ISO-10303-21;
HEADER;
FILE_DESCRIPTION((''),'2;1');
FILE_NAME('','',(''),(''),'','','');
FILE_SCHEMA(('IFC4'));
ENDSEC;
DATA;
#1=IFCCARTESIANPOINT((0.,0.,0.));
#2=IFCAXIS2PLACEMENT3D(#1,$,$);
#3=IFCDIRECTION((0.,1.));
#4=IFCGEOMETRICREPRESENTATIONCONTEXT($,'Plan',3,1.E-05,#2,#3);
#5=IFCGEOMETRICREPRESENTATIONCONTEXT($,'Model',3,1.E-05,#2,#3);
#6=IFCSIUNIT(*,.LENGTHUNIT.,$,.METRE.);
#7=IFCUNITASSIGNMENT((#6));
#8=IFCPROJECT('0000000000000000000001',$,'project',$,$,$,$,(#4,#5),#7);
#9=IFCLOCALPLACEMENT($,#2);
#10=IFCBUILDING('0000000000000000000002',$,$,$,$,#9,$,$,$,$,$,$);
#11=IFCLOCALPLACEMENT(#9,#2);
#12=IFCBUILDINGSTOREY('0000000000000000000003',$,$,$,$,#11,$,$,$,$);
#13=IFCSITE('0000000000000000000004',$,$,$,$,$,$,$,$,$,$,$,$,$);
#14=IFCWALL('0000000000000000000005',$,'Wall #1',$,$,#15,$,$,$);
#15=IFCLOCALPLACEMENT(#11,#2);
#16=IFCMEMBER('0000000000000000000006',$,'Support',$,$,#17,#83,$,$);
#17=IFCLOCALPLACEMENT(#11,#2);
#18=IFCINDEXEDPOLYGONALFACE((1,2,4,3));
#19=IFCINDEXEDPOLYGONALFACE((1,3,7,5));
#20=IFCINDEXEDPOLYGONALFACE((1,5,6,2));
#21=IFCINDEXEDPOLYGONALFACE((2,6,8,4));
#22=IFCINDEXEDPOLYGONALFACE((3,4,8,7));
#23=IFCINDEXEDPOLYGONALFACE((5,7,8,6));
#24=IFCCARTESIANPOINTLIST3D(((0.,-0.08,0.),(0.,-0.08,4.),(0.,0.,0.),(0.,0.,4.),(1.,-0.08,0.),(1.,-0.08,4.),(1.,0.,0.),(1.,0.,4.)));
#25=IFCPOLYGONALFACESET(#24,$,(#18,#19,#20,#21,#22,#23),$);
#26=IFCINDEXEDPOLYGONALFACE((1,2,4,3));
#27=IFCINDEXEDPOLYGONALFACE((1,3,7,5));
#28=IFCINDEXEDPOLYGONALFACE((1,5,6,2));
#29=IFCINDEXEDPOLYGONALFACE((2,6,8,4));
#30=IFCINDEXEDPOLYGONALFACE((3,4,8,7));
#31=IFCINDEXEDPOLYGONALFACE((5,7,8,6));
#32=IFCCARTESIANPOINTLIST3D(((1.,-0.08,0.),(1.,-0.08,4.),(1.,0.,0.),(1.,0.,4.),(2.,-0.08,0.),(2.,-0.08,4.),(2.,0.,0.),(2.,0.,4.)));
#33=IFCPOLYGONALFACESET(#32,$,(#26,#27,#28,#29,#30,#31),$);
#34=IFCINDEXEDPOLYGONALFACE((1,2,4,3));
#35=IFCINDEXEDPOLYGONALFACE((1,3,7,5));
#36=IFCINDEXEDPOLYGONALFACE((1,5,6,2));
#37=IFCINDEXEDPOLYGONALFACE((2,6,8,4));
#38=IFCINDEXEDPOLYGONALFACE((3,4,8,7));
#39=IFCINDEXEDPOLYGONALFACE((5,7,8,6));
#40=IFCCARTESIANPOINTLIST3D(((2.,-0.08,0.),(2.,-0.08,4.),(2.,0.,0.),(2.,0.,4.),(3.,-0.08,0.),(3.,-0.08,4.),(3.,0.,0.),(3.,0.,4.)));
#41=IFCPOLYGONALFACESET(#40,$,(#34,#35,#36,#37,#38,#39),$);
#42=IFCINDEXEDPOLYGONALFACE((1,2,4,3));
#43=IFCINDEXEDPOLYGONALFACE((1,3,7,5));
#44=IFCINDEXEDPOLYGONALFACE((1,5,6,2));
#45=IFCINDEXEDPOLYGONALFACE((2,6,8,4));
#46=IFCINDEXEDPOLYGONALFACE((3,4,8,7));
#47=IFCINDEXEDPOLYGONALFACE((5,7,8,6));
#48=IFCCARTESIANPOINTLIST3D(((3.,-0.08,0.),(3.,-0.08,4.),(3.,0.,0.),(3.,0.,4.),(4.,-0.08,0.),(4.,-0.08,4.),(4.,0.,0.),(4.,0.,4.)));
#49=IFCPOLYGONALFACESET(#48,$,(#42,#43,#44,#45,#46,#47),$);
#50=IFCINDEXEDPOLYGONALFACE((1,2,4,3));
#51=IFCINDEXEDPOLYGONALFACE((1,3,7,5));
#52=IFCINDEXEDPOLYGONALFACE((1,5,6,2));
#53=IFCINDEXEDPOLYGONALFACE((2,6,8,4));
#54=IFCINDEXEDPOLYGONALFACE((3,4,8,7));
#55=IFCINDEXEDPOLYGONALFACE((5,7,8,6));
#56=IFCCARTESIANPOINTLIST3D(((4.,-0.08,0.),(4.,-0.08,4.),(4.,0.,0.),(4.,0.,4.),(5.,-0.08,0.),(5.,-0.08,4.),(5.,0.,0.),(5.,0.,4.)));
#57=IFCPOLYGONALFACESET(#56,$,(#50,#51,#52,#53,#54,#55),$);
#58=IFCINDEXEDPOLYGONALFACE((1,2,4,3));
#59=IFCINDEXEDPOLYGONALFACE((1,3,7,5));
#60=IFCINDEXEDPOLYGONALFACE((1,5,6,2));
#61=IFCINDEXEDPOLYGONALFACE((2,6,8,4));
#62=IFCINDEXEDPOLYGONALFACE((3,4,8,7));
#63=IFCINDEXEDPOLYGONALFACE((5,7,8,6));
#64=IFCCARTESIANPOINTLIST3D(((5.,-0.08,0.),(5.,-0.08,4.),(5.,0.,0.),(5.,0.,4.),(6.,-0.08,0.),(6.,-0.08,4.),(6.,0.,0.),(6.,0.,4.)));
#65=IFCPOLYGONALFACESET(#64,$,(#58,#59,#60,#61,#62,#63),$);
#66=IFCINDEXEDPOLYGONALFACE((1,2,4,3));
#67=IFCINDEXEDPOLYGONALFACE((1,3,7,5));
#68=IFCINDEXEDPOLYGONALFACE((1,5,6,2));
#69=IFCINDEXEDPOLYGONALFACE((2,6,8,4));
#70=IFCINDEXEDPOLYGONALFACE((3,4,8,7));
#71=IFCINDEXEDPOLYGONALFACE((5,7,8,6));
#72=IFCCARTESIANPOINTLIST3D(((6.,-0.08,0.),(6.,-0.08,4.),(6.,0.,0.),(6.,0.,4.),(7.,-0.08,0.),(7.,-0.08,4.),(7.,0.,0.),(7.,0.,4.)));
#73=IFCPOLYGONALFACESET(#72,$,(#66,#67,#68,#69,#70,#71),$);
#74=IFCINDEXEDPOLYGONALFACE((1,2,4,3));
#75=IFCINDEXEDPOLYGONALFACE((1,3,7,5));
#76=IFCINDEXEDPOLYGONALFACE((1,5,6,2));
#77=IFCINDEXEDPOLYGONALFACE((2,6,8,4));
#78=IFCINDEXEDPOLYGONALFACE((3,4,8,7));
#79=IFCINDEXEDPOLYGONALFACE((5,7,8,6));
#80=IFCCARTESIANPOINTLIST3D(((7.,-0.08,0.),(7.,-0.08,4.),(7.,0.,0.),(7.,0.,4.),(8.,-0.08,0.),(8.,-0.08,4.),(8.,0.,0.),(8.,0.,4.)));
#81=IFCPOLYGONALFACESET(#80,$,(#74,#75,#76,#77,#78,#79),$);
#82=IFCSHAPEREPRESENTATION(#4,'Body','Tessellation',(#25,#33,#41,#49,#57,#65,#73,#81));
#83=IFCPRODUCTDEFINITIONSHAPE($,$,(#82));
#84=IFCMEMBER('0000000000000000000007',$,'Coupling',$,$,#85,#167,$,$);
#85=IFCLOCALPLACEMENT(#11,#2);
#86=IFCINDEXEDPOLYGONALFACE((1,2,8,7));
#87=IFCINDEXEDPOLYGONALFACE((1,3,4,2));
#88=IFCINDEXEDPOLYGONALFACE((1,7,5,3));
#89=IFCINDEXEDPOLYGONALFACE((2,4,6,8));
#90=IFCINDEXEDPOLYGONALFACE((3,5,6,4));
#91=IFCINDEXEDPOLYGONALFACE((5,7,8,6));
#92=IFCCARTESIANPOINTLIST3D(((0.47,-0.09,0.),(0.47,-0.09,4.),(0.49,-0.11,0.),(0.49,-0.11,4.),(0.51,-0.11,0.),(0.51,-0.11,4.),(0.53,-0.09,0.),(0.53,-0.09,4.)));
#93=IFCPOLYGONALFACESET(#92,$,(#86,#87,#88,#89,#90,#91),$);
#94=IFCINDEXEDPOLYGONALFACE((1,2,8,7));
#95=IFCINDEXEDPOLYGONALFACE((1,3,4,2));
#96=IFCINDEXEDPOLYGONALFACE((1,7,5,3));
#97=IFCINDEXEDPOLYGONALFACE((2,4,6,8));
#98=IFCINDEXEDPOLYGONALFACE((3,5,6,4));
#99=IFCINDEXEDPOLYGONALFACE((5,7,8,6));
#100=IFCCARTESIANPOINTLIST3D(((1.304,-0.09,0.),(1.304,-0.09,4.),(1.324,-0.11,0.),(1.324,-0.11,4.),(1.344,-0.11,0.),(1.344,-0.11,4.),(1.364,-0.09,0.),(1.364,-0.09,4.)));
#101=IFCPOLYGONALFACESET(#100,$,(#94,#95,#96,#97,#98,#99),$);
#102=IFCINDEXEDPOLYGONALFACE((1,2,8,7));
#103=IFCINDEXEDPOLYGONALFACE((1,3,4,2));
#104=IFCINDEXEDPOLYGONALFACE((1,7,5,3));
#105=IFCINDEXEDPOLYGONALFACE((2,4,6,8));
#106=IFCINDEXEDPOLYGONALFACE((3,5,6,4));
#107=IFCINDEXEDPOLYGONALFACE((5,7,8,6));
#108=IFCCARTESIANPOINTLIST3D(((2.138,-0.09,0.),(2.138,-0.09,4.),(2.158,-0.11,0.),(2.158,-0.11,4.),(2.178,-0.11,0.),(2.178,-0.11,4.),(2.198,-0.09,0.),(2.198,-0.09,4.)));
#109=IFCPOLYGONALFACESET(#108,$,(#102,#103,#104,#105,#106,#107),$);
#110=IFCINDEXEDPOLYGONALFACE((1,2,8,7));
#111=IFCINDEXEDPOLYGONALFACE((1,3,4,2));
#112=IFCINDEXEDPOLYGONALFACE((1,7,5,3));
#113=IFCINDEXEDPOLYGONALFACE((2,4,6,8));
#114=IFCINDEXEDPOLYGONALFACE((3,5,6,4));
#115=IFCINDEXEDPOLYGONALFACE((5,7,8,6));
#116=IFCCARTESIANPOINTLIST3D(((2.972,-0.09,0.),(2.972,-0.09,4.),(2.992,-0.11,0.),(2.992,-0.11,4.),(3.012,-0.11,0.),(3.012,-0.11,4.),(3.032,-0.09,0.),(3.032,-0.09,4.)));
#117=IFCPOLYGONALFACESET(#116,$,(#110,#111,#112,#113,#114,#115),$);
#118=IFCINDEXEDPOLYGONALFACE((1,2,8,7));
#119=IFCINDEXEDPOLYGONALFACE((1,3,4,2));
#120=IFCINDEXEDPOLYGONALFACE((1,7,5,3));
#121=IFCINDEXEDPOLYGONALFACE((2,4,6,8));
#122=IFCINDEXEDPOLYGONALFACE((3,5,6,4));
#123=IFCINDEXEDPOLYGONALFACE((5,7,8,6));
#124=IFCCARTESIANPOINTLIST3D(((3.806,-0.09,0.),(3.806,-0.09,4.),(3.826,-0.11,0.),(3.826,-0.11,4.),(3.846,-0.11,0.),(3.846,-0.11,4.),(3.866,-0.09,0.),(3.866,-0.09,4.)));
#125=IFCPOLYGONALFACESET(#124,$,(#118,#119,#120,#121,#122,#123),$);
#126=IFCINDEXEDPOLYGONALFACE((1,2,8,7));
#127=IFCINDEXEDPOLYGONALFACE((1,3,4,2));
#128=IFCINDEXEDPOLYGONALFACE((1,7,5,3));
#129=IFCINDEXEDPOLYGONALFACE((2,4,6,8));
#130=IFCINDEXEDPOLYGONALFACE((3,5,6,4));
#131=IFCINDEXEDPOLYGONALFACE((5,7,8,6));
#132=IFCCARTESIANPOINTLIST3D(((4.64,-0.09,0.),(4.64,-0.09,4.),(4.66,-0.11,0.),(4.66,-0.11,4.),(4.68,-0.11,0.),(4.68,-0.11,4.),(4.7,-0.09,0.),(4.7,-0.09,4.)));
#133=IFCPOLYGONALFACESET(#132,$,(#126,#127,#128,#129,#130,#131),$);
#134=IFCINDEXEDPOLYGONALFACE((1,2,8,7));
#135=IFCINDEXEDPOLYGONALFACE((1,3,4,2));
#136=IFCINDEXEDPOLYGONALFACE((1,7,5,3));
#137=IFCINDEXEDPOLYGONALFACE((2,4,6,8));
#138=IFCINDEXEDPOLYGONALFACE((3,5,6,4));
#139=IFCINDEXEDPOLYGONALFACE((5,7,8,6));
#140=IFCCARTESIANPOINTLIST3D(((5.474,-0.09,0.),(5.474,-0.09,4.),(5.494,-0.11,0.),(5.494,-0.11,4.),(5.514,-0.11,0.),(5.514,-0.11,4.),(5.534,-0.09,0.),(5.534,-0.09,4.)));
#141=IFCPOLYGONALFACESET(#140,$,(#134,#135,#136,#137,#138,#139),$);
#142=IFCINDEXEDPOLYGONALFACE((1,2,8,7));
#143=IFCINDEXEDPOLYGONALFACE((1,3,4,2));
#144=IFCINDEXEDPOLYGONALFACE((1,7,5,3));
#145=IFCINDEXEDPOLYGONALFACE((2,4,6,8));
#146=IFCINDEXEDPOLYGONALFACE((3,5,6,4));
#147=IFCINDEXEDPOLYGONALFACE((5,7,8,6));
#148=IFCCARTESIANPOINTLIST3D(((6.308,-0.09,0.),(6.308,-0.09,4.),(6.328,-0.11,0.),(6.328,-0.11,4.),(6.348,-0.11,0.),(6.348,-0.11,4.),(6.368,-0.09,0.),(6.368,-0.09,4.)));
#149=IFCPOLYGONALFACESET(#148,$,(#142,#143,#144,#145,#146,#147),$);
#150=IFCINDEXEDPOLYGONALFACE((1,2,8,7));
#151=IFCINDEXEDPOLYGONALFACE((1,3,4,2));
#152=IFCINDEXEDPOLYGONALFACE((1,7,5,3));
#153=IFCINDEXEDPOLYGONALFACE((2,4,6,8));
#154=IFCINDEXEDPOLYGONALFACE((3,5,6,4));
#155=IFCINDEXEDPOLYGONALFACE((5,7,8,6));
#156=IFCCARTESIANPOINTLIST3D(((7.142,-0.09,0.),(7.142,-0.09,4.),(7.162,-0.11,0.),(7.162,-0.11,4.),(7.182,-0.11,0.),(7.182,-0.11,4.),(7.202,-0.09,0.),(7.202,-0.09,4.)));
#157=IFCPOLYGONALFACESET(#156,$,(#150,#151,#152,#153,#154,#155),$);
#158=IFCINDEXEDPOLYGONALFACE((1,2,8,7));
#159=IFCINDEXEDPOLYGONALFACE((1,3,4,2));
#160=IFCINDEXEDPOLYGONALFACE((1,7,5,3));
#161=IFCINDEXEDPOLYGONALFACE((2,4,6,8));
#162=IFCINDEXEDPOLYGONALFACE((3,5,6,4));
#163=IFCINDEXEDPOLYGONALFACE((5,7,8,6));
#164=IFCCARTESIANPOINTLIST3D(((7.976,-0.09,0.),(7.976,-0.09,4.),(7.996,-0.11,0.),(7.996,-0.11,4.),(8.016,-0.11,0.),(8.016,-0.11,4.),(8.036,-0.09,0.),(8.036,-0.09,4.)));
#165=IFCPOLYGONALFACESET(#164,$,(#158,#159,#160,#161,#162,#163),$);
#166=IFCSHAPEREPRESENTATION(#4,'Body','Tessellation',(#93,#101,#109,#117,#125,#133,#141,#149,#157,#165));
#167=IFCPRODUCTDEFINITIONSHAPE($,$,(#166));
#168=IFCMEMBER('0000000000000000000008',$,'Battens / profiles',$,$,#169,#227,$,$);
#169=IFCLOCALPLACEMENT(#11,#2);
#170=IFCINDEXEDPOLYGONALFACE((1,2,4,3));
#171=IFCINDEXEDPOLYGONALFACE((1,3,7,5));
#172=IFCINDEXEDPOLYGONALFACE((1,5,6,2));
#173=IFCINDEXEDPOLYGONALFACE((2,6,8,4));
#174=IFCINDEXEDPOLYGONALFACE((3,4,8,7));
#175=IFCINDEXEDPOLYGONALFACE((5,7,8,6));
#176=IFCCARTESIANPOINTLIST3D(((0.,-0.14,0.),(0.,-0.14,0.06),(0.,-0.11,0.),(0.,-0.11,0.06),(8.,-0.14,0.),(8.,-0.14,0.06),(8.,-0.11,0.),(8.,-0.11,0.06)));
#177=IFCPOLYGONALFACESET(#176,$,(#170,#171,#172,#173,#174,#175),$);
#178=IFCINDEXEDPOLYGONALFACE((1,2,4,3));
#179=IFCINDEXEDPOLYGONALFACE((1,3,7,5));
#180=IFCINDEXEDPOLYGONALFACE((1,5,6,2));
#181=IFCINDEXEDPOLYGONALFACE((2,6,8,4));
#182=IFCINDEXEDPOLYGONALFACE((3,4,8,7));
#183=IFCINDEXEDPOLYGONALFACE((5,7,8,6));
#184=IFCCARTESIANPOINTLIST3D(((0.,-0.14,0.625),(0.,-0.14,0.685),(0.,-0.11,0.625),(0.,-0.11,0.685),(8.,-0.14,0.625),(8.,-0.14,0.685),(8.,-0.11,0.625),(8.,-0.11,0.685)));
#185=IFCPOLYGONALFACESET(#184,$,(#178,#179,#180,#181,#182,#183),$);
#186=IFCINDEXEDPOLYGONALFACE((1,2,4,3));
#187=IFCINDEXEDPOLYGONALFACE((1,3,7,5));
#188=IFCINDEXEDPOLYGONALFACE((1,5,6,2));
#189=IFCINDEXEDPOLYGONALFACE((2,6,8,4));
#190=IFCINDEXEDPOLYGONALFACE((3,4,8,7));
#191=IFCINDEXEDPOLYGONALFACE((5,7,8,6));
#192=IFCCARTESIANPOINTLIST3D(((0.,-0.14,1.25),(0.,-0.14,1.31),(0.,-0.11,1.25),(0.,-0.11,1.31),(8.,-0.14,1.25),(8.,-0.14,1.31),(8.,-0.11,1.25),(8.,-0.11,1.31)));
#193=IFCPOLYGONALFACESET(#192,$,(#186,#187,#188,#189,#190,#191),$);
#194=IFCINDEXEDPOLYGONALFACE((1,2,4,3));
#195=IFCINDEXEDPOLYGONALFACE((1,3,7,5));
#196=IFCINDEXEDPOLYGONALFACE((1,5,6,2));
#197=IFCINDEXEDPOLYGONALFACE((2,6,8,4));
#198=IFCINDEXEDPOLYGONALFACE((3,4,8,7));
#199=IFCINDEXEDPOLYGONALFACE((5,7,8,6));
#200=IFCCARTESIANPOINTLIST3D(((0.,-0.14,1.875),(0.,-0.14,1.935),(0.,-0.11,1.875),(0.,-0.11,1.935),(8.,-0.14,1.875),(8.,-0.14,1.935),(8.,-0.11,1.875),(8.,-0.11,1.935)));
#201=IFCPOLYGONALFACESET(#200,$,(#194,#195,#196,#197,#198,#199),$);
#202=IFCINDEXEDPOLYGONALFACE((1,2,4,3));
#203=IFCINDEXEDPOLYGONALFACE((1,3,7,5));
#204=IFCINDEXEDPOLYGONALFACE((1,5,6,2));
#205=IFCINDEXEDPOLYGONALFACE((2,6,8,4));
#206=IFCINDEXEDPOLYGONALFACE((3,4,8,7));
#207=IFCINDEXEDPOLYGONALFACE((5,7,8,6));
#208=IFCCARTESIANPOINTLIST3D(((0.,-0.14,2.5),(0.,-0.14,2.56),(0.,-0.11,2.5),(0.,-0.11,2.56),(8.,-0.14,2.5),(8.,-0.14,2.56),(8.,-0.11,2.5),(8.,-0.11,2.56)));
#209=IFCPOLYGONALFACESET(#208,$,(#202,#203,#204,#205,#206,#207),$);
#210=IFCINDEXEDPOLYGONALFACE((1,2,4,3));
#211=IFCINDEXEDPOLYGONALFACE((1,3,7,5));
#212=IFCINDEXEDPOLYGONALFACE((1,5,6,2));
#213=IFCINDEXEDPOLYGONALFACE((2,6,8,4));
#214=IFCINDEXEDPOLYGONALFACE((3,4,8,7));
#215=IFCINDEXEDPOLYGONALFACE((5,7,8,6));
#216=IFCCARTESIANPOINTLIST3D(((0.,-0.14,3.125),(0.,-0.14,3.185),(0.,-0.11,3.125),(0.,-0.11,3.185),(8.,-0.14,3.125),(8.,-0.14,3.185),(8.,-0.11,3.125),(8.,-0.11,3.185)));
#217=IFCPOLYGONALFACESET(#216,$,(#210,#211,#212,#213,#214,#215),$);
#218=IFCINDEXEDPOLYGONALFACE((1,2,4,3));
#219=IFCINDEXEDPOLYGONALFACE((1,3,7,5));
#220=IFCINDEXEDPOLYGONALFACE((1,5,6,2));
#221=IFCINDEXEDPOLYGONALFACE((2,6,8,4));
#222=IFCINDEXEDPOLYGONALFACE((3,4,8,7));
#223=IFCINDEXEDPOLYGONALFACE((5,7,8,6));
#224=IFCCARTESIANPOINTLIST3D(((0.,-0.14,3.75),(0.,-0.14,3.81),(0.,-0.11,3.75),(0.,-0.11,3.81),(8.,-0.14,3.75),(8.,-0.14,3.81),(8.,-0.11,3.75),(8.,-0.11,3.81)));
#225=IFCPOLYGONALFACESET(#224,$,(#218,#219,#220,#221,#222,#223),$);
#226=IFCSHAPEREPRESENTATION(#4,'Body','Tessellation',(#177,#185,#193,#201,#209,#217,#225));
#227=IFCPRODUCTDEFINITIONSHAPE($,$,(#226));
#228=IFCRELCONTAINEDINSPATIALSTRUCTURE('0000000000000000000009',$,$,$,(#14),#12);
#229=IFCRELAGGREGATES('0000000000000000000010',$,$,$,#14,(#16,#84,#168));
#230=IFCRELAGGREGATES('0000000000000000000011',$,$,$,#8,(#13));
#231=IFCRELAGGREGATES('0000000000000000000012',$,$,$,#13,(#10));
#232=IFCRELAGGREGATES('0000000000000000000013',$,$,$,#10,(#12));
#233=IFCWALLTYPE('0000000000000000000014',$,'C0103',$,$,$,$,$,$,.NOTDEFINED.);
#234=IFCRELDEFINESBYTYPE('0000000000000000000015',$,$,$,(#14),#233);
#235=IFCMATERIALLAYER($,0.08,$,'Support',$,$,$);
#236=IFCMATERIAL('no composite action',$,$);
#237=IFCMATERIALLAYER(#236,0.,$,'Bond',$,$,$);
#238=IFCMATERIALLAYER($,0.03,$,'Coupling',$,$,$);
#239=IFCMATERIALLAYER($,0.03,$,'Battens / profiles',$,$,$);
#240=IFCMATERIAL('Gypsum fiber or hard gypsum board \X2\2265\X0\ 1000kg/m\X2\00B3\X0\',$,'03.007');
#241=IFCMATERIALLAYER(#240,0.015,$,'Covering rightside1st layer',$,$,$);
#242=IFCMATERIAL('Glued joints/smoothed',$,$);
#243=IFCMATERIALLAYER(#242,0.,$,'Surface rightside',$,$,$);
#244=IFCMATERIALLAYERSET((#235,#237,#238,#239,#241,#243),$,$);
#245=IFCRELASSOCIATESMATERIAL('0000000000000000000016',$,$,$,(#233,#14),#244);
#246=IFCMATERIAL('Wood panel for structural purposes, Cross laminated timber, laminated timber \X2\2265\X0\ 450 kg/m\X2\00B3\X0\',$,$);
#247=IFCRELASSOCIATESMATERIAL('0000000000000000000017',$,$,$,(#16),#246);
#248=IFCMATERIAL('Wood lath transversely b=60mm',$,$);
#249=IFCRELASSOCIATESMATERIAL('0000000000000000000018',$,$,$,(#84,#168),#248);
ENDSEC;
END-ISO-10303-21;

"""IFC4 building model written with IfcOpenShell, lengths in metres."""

from ifc_helpers import new_model, si_unit, direction, frame, frame_2d, origin, place, context, project, spatial, polyline, rectangle, outline, extrude, material, layer, layer_set, type_object, element, aggregate, save


model = new_model("IFC4")

# Units and contexts
plan_context = context("Plan", 3, precision=1e-05, world=origin(), true_north=direction((0.0, 1.0)))
model_context = context("Model", 3, precision=1e-05, world=origin(), true_north=direction((0.0, 1.0)))
ifc_project = project(units=[si_unit("LENGTHUNIT", "METRE")], contexts=[plan_context, model_context])

# Site, building, storey
site = spatial("IfcSite", under=ifc_project)
building_placement = place(None, origin())
building = spatial("IfcBuilding", under=site, at=building_placement)
storey_placement = place(building_placement, origin())
storey = spatial("IfcBuildingStorey", under=building, at=storey_placement)

# Wall, members
ifc_layer_1 = layer(None, 0.08, Name="Support")
ifc_material_1 = material(Name="no composite action")
ifc_layer_2 = layer(ifc_material_1, 0.0, Name="Bond")
ifc_layer_3 = layer(None, 0.03, Name="Coupling")
ifc_layer_4 = layer(None, 0.03, Name="Battens / profiles")
ifc_material_2 = material(Name="Gypsum fiber or hard gypsum board ≥ 1000kg/m³", Category="03.007")
ifc_layer_5 = layer(ifc_material_2, 0.015, Name="Covering rightside1st layer")
ifc_material_3 = material(Name="Glued joints/smoothed")
ifc_layer_6 = layer(ifc_material_3, 0.0, Name="Surface rightside")
ifc_layer_set = layer_set([ifc_layer_1, ifc_layer_2, ifc_layer_3, ifc_layer_4, ifc_layer_5, ifc_layer_6])
wall_type = type_object("IfcWallType", Name="C0103", PredefinedType="NOTDEFINED", material=ifc_layer_set)
wall_placement = place(None, frame((0.0, 0.0, 0.0), z_axis=(0.0, -1.0, 0.0), x_axis=(1.0, 0.0, 0.0)))
wall = element("IfcWall", 1, at=wall_placement, inside=storey, type_object=wall_type, material=ifc_layer_set, Name="Wall #1")
ifc_material_4 = material(Name="Wood panel for structural purposes, Cross laminated timber, laminated timber ≥ 450 kg/m³")
member_1_placement = place(wall_placement, origin())
member_1 = element("IfcMember", 2, at=member_1_placement, material=ifc_material_4, Name="Support", context=plan_context, shape_type="SweptSolid", body=[
    extrude(rectangle(XDim=1.0, YDim=0.08, at=frame_2d((0.5, 0.04), x_axis=(1.0, 0.0))), frame((0.0, 4.0, 0.0), z_axis=(0.0, -1.0, 0.0), x_axis=(1.0, 0.0, 0.0)), (0.0, 0.0, 1.0), 4.0),
    extrude(rectangle(XDim=1.0, YDim=0.08, at=frame_2d((0.5, 0.04), x_axis=(1.0, 0.0))), frame((1.0, 4.0, 0.0), z_axis=(0.0, -1.0, 0.0), x_axis=(1.0, 0.0, 0.0)), (0.0, 0.0, 1.0), 4.0),
    extrude(rectangle(XDim=1.0, YDim=0.08, at=frame_2d((0.5, 0.04), x_axis=(1.0, 0.0))), frame((2.0, 4.0, 0.0), z_axis=(0.0, -1.0, 0.0), x_axis=(1.0, 0.0, 0.0)), (0.0, 0.0, 1.0), 4.0),
    extrude(rectangle(XDim=1.0, YDim=0.08, at=frame_2d((0.5, 0.04), x_axis=(1.0, 0.0))), frame((3.0, 4.0, 0.0), z_axis=(0.0, -1.0, 0.0), x_axis=(1.0, 0.0, 0.0)), (0.0, 0.0, 1.0), 4.0),
    extrude(rectangle(XDim=1.0, YDim=0.08, at=frame_2d((0.5, 0.04), x_axis=(1.0, 0.0))), frame((4.0, 4.0, 0.0), z_axis=(0.0, -1.0, 0.0), x_axis=(1.0, 0.0, 0.0)), (0.0, 0.0, 1.0), 4.0),
    extrude(rectangle(XDim=1.0, YDim=0.08, at=frame_2d((0.5, 0.04), x_axis=(1.0, 0.0))), frame((5.0, 4.0, 0.0), z_axis=(0.0, -1.0, 0.0), x_axis=(1.0, 0.0, 0.0)), (0.0, 0.0, 1.0), 4.0),
    extrude(rectangle(XDim=1.0, YDim=0.08, at=frame_2d((0.5, 0.04), x_axis=(1.0, 0.0))), frame((6.0, 4.0, 0.0), z_axis=(0.0, -1.0, 0.0), x_axis=(1.0, 0.0, 0.0)), (0.0, 0.0, 1.0), 4.0),
    extrude(rectangle(XDim=1.0, YDim=0.08, at=frame_2d((0.5, 0.04), x_axis=(1.0, 0.0))), frame((7.0, 4.0, 0.0), z_axis=(0.0, -1.0, 0.0), x_axis=(1.0, 0.0, 0.0)), (0.0, 0.0, 1.0), 4.0),
])
ifc_material_5 = material(Name="Wood lath transversely b=60mm")
member_2_placement = place(wall_placement, origin())
member_2 = element("IfcMember", 3, at=member_2_placement, material=ifc_material_5, Name="Coupling", context=plan_context, shape_type="SweptSolid", body=[
    extrude(outline(polyline([(0.0, 0.0), (0.06, 0.0), (0.04, 0.02), (0.02, 0.02), (0.0, 0.0)])), frame((0.47, 4.0, 0.09), z_axis=(0.0, -1.0, 0.0), x_axis=(1.0, 0.0, 0.0)), (0.0, 0.0, 1.0), 4.0),
    extrude(outline(polyline([(0.0, 0.0), (0.06, 0.0), (0.04, 0.02), (0.02, 0.02), (0.0, 0.0)])), frame((1.304, 4.0, 0.09), z_axis=(0.0, -1.0, 0.0), x_axis=(1.0, 0.0, 0.0)), (0.0, 0.0, 1.0), 4.0),
    extrude(outline(polyline([(0.0, 0.0), (0.06, 0.0), (0.04, 0.02), (0.02, 0.02), (0.0, 0.0)])), frame((2.138, 4.0, 0.09), z_axis=(0.0, -1.0, 0.0), x_axis=(1.0, 0.0, 0.0)), (0.0, 0.0, 1.0), 4.0),
    extrude(outline(polyline([(0.0, 0.0), (0.06, 0.0), (0.04, 0.02), (0.02, 0.02), (0.0, 0.0)])), frame((2.972, 4.0, 0.09), z_axis=(0.0, -1.0, 0.0), x_axis=(1.0, 0.0, 0.0)), (0.0, 0.0, 1.0), 4.0),
    extrude(outline(polyline([(0.0, 0.0), (0.06, 0.0), (0.04, 0.02), (0.02, 0.02), (0.0, 0.0)])), frame((3.806, 4.0, 0.09), z_axis=(0.0, -1.0, 0.0), x_axis=(1.0, 0.0, 0.0)), (0.0, 0.0, 1.0), 4.0),
    extrude(outline(polyline([(0.0, 0.0), (0.06, 0.0), (0.04, 0.02), (0.02, 0.02), (0.0, 0.0)])), frame((4.64, 4.0, 0.09), z_axis=(0.0, -1.0, 0.0), x_axis=(1.0, 0.0, 0.0)), (0.0, 0.0, 1.0), 4.0),
    extrude(outline(polyline([(0.0, 0.0), (0.06, 0.0), (0.04, 0.02), (0.02, 0.02), (0.0, 0.0)])), frame((5.474, 4.0, 0.09), z_axis=(0.0, -1.0, 0.0), x_axis=(1.0, 0.0, 0.0)), (0.0, 0.0, 1.0), 4.0),
    extrude(outline(polyline([(0.0, 0.0), (0.06, 0.0), (0.04, 0.02), (0.02, 0.02), (0.0, 0.0)])), frame((6.308, 4.0, 0.09), z_axis=(0.0, -1.0, 0.0), x_axis=(1.0, 0.0, 0.0)), (0.0, 0.0, 1.0), 4.0),
    extrude(outline(polyline([(0.0, 0.0), (0.06, 0.0), (0.04, 0.02), (0.02, 0.02), (0.0, 0.0)])), frame((7.142, 4.0, 0.09), z_axis=(0.0, -1.0, 0.0), x_axis=(1.0, 0.0, 0.0)), (0.0, 0.0, 1.0), 4.0),
    extrude(outline(polyline([(0.0, 0.0), (0.06, 0.0), (0.04, 0.02), (0.02, 0.02), (0.0, 0.0)])), frame((7.976, 4.0, 0.09), z_axis=(0.0, -1.0, 0.0), x_axis=(1.0, 0.0, 0.0)), (0.0, 0.0, 1.0), 4.0),
])
member_3_placement = place(wall_placement, origin())
member_3 = element("IfcMember", 4, at=member_3_placement, material=ifc_material_5, Name="Battens / profiles", context=plan_context, shape_type="SweptSolid", body=[
    extrude(rectangle(XDim=0.06, YDim=0.03, at=frame_2d((0.03, 0.015), x_axis=(1.0, 0.0))), frame((0.0, 0.0, 0.11), z_axis=(1.0, 0.0, 0.0), x_axis=(0.0, 1.0, 0.0)), (0.0, 0.0, 1.0), 8.0),
    extrude(rectangle(XDim=0.06, YDim=0.03, at=frame_2d((0.03, 0.015), x_axis=(1.0, 0.0))), frame((0.0, 0.625, 0.11), z_axis=(1.0, 0.0, 0.0), x_axis=(0.0, 1.0, 0.0)), (0.0, 0.0, 1.0), 8.0),
    extrude(rectangle(XDim=0.06, YDim=0.03, at=frame_2d((0.03, 0.015), x_axis=(1.0, 0.0))), frame((0.0, 1.25, 0.11), z_axis=(1.0, 0.0, 0.0), x_axis=(0.0, 1.0, 0.0)), (0.0, 0.0, 1.0), 8.0),
    extrude(rectangle(XDim=0.06, YDim=0.03, at=frame_2d((0.03, 0.015), x_axis=(1.0, 0.0))), frame((0.0, 1.875, 0.11), z_axis=(1.0, 0.0, 0.0), x_axis=(0.0, 1.0, 0.0)), (0.0, 0.0, 1.0), 8.0),
    extrude(rectangle(XDim=0.06, YDim=0.03, at=frame_2d((0.03, 0.015), x_axis=(1.0, 0.0))), frame((0.0, 2.5, 0.11), z_axis=(1.0, 0.0, 0.0), x_axis=(0.0, 1.0, 0.0)), (0.0, 0.0, 1.0), 8.0),
    extrude(rectangle(XDim=0.06, YDim=0.03, at=frame_2d((0.03, 0.015), x_axis=(1.0, 0.0))), frame((0.0, 3.125, 0.11), z_axis=(1.0, 0.0, 0.0), x_axis=(0.0, 1.0, 0.0)), (0.0, 0.0, 1.0), 8.0),
    extrude(rectangle(XDim=0.06, YDim=0.03, at=frame_2d((0.03, 0.015), x_axis=(1.0, 0.0))), frame((0.0, 3.75, 0.11), z_axis=(1.0, 0.0, 0.0), x_axis=(0.0, 1.0, 0.0)), (0.0, 0.0, 1.0), 8.0),
])
aggregate(wall, [member_1, member_2, member_3])

save(model, "model.ifc")
